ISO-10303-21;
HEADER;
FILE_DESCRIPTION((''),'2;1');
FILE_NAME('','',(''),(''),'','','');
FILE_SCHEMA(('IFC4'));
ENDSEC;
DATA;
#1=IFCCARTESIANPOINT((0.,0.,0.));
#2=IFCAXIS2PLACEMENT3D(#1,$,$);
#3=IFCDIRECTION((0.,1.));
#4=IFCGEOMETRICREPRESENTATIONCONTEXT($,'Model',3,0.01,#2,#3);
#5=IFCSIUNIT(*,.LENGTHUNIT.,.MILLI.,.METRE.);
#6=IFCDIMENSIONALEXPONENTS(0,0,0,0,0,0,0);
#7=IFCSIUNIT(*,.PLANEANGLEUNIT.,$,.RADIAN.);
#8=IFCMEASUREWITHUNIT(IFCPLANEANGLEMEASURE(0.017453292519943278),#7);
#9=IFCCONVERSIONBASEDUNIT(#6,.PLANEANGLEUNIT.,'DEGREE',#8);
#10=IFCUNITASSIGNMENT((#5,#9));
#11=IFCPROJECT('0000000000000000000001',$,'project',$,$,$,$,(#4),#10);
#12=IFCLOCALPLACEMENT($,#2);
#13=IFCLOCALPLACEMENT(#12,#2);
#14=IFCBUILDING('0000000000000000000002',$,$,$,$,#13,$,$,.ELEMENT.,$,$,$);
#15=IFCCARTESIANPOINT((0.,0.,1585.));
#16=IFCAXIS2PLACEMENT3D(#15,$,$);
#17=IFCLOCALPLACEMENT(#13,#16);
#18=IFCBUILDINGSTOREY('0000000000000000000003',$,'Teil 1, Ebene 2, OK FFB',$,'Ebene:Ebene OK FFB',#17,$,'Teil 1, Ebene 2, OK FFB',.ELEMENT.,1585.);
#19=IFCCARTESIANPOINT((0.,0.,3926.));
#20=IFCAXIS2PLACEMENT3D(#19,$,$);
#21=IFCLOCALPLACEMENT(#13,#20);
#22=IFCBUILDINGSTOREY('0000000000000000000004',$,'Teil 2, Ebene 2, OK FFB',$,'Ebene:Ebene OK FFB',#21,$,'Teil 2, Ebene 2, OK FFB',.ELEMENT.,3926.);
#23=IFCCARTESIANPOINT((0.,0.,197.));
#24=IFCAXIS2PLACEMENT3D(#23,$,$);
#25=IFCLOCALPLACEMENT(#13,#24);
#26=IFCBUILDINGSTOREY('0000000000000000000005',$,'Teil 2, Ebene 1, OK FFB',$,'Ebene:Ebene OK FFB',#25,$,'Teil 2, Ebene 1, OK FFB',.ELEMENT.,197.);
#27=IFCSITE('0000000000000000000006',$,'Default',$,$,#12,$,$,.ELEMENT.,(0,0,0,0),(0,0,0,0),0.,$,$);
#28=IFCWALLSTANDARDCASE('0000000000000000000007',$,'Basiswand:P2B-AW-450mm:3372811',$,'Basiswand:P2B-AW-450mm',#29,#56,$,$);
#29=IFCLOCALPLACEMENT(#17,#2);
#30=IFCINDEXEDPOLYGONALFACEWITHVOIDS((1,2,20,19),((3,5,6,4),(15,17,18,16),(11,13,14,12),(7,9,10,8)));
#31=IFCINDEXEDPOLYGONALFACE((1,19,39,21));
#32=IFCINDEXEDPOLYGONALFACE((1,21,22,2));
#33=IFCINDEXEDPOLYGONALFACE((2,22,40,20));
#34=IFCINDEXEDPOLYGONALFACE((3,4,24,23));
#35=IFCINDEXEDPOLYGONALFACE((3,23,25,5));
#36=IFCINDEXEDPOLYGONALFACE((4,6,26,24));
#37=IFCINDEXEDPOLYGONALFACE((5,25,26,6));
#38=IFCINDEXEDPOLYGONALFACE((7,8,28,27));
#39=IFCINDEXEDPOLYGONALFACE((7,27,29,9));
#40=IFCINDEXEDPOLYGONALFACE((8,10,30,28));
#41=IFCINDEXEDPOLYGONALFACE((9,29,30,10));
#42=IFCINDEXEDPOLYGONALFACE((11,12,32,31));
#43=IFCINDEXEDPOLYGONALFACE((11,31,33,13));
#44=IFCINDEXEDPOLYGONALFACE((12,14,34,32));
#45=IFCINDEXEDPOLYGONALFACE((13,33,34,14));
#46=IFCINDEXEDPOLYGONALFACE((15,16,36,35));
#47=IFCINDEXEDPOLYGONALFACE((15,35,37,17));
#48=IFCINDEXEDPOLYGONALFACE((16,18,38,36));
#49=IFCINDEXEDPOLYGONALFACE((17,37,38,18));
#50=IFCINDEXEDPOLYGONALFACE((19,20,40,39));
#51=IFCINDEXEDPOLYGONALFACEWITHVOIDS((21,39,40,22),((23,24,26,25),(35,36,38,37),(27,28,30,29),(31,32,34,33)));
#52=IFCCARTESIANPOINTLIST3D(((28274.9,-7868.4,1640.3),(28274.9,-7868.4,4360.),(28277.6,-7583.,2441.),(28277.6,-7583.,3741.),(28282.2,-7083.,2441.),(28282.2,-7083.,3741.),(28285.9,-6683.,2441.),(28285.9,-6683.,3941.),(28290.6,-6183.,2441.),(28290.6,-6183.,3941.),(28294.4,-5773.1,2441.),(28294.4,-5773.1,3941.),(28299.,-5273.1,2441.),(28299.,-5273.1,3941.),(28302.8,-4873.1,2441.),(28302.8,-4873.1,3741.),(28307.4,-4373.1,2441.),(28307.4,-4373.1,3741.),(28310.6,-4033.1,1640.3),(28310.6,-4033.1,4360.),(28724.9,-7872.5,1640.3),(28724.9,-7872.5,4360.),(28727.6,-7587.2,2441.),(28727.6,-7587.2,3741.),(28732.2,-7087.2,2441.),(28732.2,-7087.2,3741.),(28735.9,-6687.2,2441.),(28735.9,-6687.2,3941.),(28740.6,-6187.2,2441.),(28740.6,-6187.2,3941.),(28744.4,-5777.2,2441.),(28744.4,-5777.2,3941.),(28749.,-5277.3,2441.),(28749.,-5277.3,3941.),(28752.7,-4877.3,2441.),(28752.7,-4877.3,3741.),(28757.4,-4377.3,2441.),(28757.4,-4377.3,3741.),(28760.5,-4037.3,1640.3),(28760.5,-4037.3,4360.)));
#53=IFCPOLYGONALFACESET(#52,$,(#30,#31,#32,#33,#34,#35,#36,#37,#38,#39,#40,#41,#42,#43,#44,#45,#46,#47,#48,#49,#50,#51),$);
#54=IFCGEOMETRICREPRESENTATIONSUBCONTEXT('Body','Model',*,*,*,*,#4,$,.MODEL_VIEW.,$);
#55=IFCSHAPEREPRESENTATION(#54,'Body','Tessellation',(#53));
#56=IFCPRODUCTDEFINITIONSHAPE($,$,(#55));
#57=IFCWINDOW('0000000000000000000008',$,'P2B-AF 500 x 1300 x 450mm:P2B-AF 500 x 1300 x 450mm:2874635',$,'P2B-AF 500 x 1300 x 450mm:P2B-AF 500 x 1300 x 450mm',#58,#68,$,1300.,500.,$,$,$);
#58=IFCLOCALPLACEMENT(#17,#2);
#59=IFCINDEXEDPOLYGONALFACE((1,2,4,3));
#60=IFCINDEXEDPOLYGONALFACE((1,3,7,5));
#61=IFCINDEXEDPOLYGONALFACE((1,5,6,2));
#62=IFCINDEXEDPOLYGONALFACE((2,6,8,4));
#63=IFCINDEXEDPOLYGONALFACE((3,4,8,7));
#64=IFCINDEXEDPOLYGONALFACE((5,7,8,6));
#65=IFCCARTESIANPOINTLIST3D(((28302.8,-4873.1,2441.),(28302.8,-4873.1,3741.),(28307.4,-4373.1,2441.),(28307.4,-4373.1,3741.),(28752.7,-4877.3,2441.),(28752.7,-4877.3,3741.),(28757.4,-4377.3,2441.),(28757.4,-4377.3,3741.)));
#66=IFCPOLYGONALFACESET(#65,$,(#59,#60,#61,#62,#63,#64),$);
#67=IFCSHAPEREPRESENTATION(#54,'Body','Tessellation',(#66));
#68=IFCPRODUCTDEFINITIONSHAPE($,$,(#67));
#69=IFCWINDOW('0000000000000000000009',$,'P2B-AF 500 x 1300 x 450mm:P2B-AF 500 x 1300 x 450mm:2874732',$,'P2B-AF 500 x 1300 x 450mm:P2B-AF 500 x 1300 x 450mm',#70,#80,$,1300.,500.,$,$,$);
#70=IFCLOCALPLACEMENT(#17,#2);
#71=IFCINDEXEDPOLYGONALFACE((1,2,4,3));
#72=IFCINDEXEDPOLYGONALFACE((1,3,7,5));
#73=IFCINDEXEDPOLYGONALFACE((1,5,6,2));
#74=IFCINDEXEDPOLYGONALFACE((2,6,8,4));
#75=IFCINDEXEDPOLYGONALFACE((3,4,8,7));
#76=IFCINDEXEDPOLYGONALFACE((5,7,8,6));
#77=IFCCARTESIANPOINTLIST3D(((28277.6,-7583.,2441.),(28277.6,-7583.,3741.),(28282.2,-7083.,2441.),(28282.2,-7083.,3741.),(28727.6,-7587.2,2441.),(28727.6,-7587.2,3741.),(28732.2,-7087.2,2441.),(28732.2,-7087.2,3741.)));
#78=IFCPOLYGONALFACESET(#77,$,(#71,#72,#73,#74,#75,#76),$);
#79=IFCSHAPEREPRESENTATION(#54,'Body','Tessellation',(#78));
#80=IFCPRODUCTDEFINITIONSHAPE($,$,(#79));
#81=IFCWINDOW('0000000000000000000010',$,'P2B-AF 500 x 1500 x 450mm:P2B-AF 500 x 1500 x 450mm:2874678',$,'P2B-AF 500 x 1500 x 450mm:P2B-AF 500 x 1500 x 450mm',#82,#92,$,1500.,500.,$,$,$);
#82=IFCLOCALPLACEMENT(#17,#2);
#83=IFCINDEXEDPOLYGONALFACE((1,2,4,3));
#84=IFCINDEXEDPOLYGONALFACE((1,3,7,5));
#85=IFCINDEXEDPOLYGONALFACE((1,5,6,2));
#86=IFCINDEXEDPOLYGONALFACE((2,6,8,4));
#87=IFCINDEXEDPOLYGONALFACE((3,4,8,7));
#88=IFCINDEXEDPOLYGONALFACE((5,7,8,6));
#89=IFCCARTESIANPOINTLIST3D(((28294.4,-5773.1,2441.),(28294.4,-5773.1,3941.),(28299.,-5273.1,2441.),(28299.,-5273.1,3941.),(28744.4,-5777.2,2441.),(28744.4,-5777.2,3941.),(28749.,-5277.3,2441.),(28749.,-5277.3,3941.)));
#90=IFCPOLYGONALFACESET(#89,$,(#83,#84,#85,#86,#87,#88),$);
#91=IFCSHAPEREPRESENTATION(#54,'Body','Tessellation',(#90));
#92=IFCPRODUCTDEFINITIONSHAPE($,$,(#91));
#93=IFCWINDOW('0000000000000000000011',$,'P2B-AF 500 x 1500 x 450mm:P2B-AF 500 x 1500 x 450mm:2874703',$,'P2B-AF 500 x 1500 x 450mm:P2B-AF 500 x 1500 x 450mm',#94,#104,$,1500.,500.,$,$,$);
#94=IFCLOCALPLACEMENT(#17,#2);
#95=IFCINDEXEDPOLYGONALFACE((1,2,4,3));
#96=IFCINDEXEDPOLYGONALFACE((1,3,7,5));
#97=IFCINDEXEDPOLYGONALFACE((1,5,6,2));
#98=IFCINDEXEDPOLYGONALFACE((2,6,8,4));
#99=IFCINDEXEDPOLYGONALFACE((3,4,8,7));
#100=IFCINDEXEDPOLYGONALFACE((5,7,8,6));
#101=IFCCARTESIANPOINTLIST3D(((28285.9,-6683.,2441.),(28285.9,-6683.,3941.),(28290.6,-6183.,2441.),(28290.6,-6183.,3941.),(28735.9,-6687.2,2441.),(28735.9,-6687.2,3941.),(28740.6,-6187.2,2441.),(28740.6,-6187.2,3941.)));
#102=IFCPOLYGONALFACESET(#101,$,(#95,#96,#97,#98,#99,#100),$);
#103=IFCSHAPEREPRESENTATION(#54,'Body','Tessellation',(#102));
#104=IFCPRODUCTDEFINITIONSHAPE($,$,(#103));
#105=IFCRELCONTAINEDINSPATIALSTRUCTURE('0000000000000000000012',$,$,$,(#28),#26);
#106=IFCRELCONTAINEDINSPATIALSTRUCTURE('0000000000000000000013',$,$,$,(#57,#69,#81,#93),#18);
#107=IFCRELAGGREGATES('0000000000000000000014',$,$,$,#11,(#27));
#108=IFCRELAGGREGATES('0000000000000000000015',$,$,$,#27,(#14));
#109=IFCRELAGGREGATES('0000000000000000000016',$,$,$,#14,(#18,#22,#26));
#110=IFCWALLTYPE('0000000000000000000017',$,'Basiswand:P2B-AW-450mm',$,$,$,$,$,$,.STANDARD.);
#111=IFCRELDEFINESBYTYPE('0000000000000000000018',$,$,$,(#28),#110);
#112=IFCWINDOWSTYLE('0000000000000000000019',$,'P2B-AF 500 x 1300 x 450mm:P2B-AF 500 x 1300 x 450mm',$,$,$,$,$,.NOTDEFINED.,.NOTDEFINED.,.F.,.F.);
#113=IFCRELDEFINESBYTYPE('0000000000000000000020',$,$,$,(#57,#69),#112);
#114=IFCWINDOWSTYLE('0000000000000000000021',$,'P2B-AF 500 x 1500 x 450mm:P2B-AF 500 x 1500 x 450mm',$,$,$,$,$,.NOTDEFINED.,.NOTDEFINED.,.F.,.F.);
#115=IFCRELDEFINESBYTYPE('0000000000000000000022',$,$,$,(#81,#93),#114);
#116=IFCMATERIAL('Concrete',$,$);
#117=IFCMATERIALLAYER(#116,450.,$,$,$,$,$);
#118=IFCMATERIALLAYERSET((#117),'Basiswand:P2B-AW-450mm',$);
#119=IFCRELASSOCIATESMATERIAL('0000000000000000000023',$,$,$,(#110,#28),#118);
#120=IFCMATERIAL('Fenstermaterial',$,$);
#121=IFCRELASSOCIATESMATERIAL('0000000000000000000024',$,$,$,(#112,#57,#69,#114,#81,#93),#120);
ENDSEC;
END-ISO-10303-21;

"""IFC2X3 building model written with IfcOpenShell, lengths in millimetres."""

from ifc_helpers import new_model, entity, si_unit, converted_unit, direction, frame, frame_2d, origin, place, context, subcontext, project, spatial, rectangle, extrude, source, transform, mapped, material, layer, layer_set, layer_usage, type_object, type_shapes, element, fill, save


model = new_model("IFC2X3")

# Units and contexts
model_context = context("Model", 3, precision=0.01, world=origin(), true_north=direction((0.0, 1.0)))
body_context = subcontext(model_context, "Body", "Model", "MODEL_VIEW")
ifc_project = project(units=[si_unit("LENGTHUNIT", "METRE", prefix="MILLI"), converted_unit("PLANEANGLEUNIT", "DEGREE", entity("IfcPlaneAngleMeasure", 0.017453292519943278), si_unit("PLANEANGLEUNIT", "RADIAN"), dimensions=[0, 0, 0, 0, 0, 0, 0])], contexts=[model_context])

# Site, building, storey
site_placement = place(None, origin())
site = spatial("IfcSite", under=ifc_project, at=site_placement, Name="Default", CompositionType="ELEMENT", RefLatitude=(0, 0, 0, 0), RefLongitude=(0, 0, 0, 0), RefElevation=0.0)
building_placement = place(site_placement, origin())
building = spatial("IfcBuilding", under=site, at=building_placement, CompositionType="ELEMENT")
storey_1_placement = place(building_placement, frame((0.0, 0.0, 1585.0)))
storey_1 = spatial("IfcBuildingStorey", under=building, at=storey_1_placement, Name="Teil 1, Ebene 2, OK FFB", ObjectType="Ebene:Ebene OK FFB", LongName="Teil 1, Ebene 2, OK FFB", CompositionType="ELEMENT", Elevation=1585.0)

# Shared definitions
storey_2_placement = place(building_placement, frame((0.0, 0.0, 3926.0)))
storey_2 = spatial("IfcBuildingStorey", under=building, at=storey_2_placement, Name="Teil 2, Ebene 2, OK FFB", ObjectType="Ebene:Ebene OK FFB", LongName="Teil 2, Ebene 2, OK FFB", CompositionType="ELEMENT", Elevation=3926.0)

# Shared definitions
ifc_material_1 = material(Name="Concrete")
ifc_layer_1 = layer(ifc_material_1, 450.0)
ifc_layer_set_1 = layer_set([ifc_layer_1], Name="Basiswand:P2B-AW-450mm")
wall_type_1 = type_object("IfcWallType", Name="Basiswand:P2B-AW-450mm", PredefinedType="STANDARD", material=ifc_layer_set_1)

# Shared definitions
storey_3_placement = place(building_placement, frame((0.0, 0.0, 197.0)))
storey_3 = spatial("IfcBuildingStorey", under=building, at=storey_3_placement, Name="Teil 2, Ebene 1, OK FFB", ObjectType="Ebene:Ebene OK FFB", LongName="Teil 2, Ebene 1, OK FFB", CompositionType="ELEMENT", Elevation=197.0)

# Wall, openings, windows
ifc_layer_usage_1 = layer_usage(ifc_layer_set_1, "AXIS2", "POSITIVE", -225.0)
wall_1_placement = place(storey_3_placement, frame((28499.9, -7870.5, 3028.3), z_axis=(0.0, 0.0, 1.0), x_axis=(0.009291, 0.999957, 0.0)))
wall_1 = element("IfcWallStandardCase", 1, at=wall_1_placement, inside=storey_3, type_object=wall_type_1, material=ifc_layer_usage_1, Name="Basiswand:P2B-AW-450mm:3372811", ObjectType="Basiswand:P2B-AW-450mm", context=body_context, shape_type="SweptSolid", body=[
    extrude(rectangle(XDim=3835.4, YDim=450.0, at=frame_2d((1917.7, 0.0), x_axis=(-1.0, 0.0))), origin(), (0.0, 0.0, 1.0), 2719.7),
])
opening_1_placement = place(wall_1_placement, frame((7605.3, 28571.8, -1640.3), z_axis=(0.0, 0.0, 1.0), x_axis=(0.009291, -0.999957, 0.0)))
opening_1 = element("IfcOpeningElement", 2, at=opening_1_placement, cuts=wall_1, ObjectType="Opening", context=body_context, shape_type="SweptSolid", body=[
    extrude(rectangle(XDim=1300.0, YDim=500.0, at=frame_2d((0.0, 0.0), x_axis=(1.0, 0.0))), frame((28755.1, -4627.3, 3091.0), z_axis=(-0.999957, 0.009291, 0.0), x_axis=(0.0, 0.0, -1.0)), (0.0, 0.0, 1.0), 450.0),
])
opening_2_placement = place(wall_1_placement, frame((7605.3, 28571.8, -1640.3), z_axis=(0.0, 0.0, 1.0), x_axis=(0.009291, -0.999957, 0.0)))
opening_2 = element("IfcOpeningElement", 3, at=opening_2_placement, cuts=wall_1, ObjectType="Opening", context=body_context, shape_type="SweptSolid", body=[
    extrude(rectangle(XDim=1500.0, YDim=500.0, at=frame_2d((0.0, 0.0), x_axis=(1.0, 0.0))), frame((28746.7, -5527.3, 3191.0), z_axis=(-0.999957, 0.009291, 0.0), x_axis=(0.0, 0.0, -1.0)), (0.0, 0.0, 1.0), 450.0),
])
opening_3_placement = place(wall_1_placement, frame((7605.3, 28571.8, -1640.3), z_axis=(0.0, 0.0, 1.0), x_axis=(0.009291, -0.999957, 0.0)))
opening_3 = element("IfcOpeningElement", 4, at=opening_3_placement, cuts=wall_1, ObjectType="Opening", context=body_context, shape_type="SweptSolid", body=[
    extrude(rectangle(XDim=1500.0, YDim=500.0, at=frame_2d((0.0, 0.0), x_axis=(1.0, 0.0))), frame((28738.2, -6437.2, 3191.0), z_axis=(-0.999957, 0.009291, 0.0), x_axis=(0.0, 0.0, -1.0)), (0.0, 0.0, 1.0), 450.0),
])
opening_4_placement = place(wall_1_placement, frame((7605.3, 28571.8, -1640.3), z_axis=(0.0, 0.0, 1.0), x_axis=(0.009291, -0.999957, 0.0)))
opening_4 = element("IfcOpeningElement", 5, at=opening_4_placement, cuts=wall_1, ObjectType="Opening", context=body_context, shape_type="SweptSolid", body=[
    extrude(rectangle(XDim=1300.0, YDim=500.0, at=frame_2d((0.0, 0.0), x_axis=(1.0, 0.0))), frame((28729.9, -7337.2, 3091.0), z_axis=(-0.999957, 0.009291, 0.0), x_axis=(0.0, 0.0, -1.0)), (0.0, 0.0, 1.0), 450.0),
])
ifc_material_2 = material(Name="Fenstermaterial")
window_style_1 = type_object("IfcWindowStyle", Name="P2B-AF 500 x 1300 x 450mm:P2B-AF 500 x 1300 x 450mm", ConstructionType="NOTDEFINED", OperationType="NOTDEFINED", ParameterTakesPrecedence=False, Sizeable=False, material=ifc_material_2)
shared_shape_1 = source(origin(), body_context, "Body", "SweptSolid", [
    extrude(rectangle(XDim=450.0, YDim=500.0, at=frame_2d((0.0, 0.0), x_axis=(1.0, 0.0))), frame((250.0, -225.0, 0.0), z_axis=(0.0, 0.0, 1.0), x_axis=(0.0, 1.0, 0.0)), (0.0, 0.0, 1.0), 1300.0),
])
type_shapes(window_style_1, [shared_shape_1])
window_1_placement = place(opening_1_placement, frame((28302.8, -4873.1, 2441.0), z_axis=(0.0, 0.0, 1.0), x_axis=(0.009291, 0.999957, 0.0)))
window_1 = element("IfcWindow", 6, at=window_1_placement, inside=storey_1, type_object=window_style_1, material=ifc_material_2, Name="P2B-AF 500 x 1300 x 450mm:P2B-AF 500 x 1300 x 450mm:2874635", ObjectType="P2B-AF 500 x 1300 x 450mm:P2B-AF 500 x 1300 x 450mm", OverallHeight=1300.0, OverallWidth=500.0, context=body_context, shape_type="MappedRepresentation", body=[
    mapped(shared_shape_1, transform((0.0, 0.0, 0.0), scale=1.0)),
])
fill(opening_1, window_1)
window_2_placement = place(opening_4_placement, frame((28277.6, -7583.0, 2441.0), z_axis=(0.0, 0.0, 1.0), x_axis=(0.009291, 0.999957, 0.0)))
window_2 = element("IfcWindow", 7, at=window_2_placement, inside=storey_1, type_object=window_style_1, material=ifc_material_2, Name="P2B-AF 500 x 1300 x 450mm:P2B-AF 500 x 1300 x 450mm:2874732", ObjectType="P2B-AF 500 x 1300 x 450mm:P2B-AF 500 x 1300 x 450mm", OverallHeight=1300.0, OverallWidth=500.0, context=body_context, shape_type="MappedRepresentation", body=[
    mapped(shared_shape_1, transform((0.0, 0.0, 0.0), scale=1.0)),
])
fill(opening_4, window_2)
window_style_2 = type_object("IfcWindowStyle", Name="P2B-AF 500 x 1500 x 450mm:P2B-AF 500 x 1500 x 450mm", ConstructionType="NOTDEFINED", OperationType="NOTDEFINED", ParameterTakesPrecedence=False, Sizeable=False, material=ifc_material_2)
shared_shape_2 = source(origin(), body_context, "Body", "SweptSolid", [
    extrude(rectangle(XDim=450.0, YDim=500.0, at=frame_2d((0.0, 0.0), x_axis=(1.0, 0.0))), frame((250.0, -225.0, 0.0), z_axis=(0.0, 0.0, 1.0), x_axis=(0.0, 1.0, 0.0)), (0.0, 0.0, 1.0), 1500.0),
])
type_shapes(window_style_2, [shared_shape_2])
window_3_placement = place(opening_2_placement, frame((28294.4, -5773.1, 2441.0), z_axis=(0.0, 0.0, 1.0), x_axis=(0.009291, 0.999957, 0.0)))
window_3 = element("IfcWindow", 8, at=window_3_placement, inside=storey_1, type_object=window_style_2, material=ifc_material_2, Name="P2B-AF 500 x 1500 x 450mm:P2B-AF 500 x 1500 x 450mm:2874678", ObjectType="P2B-AF 500 x 1500 x 450mm:P2B-AF 500 x 1500 x 450mm", OverallHeight=1500.0, OverallWidth=500.0, context=body_context, shape_type="MappedRepresentation", body=[
    mapped(shared_shape_2, transform((0.0, 0.0, 0.0), scale=1.0)),
])
fill(opening_2, window_3)
window_4_placement = place(opening_3_placement, frame((28285.9, -6683.0, 2441.0), z_axis=(0.0, 0.0, 1.0), x_axis=(0.009291, 0.999957, 0.0)))
window_4 = element("IfcWindow", 9, at=window_4_placement, inside=storey_1, type_object=window_style_2, material=ifc_material_2, Name="P2B-AF 500 x 1500 x 450mm:P2B-AF 500 x 1500 x 450mm:2874703", ObjectType="P2B-AF 500 x 1500 x 450mm:P2B-AF 500 x 1500 x 450mm", OverallHeight=1500.0, OverallWidth=500.0, context=body_context, shape_type="MappedRepresentation", body=[
    mapped(shared_shape_2, transform((0.0, 0.0, 0.0), scale=1.0)),
])
fill(opening_3, window_4)

save(model, "model.ifc")
